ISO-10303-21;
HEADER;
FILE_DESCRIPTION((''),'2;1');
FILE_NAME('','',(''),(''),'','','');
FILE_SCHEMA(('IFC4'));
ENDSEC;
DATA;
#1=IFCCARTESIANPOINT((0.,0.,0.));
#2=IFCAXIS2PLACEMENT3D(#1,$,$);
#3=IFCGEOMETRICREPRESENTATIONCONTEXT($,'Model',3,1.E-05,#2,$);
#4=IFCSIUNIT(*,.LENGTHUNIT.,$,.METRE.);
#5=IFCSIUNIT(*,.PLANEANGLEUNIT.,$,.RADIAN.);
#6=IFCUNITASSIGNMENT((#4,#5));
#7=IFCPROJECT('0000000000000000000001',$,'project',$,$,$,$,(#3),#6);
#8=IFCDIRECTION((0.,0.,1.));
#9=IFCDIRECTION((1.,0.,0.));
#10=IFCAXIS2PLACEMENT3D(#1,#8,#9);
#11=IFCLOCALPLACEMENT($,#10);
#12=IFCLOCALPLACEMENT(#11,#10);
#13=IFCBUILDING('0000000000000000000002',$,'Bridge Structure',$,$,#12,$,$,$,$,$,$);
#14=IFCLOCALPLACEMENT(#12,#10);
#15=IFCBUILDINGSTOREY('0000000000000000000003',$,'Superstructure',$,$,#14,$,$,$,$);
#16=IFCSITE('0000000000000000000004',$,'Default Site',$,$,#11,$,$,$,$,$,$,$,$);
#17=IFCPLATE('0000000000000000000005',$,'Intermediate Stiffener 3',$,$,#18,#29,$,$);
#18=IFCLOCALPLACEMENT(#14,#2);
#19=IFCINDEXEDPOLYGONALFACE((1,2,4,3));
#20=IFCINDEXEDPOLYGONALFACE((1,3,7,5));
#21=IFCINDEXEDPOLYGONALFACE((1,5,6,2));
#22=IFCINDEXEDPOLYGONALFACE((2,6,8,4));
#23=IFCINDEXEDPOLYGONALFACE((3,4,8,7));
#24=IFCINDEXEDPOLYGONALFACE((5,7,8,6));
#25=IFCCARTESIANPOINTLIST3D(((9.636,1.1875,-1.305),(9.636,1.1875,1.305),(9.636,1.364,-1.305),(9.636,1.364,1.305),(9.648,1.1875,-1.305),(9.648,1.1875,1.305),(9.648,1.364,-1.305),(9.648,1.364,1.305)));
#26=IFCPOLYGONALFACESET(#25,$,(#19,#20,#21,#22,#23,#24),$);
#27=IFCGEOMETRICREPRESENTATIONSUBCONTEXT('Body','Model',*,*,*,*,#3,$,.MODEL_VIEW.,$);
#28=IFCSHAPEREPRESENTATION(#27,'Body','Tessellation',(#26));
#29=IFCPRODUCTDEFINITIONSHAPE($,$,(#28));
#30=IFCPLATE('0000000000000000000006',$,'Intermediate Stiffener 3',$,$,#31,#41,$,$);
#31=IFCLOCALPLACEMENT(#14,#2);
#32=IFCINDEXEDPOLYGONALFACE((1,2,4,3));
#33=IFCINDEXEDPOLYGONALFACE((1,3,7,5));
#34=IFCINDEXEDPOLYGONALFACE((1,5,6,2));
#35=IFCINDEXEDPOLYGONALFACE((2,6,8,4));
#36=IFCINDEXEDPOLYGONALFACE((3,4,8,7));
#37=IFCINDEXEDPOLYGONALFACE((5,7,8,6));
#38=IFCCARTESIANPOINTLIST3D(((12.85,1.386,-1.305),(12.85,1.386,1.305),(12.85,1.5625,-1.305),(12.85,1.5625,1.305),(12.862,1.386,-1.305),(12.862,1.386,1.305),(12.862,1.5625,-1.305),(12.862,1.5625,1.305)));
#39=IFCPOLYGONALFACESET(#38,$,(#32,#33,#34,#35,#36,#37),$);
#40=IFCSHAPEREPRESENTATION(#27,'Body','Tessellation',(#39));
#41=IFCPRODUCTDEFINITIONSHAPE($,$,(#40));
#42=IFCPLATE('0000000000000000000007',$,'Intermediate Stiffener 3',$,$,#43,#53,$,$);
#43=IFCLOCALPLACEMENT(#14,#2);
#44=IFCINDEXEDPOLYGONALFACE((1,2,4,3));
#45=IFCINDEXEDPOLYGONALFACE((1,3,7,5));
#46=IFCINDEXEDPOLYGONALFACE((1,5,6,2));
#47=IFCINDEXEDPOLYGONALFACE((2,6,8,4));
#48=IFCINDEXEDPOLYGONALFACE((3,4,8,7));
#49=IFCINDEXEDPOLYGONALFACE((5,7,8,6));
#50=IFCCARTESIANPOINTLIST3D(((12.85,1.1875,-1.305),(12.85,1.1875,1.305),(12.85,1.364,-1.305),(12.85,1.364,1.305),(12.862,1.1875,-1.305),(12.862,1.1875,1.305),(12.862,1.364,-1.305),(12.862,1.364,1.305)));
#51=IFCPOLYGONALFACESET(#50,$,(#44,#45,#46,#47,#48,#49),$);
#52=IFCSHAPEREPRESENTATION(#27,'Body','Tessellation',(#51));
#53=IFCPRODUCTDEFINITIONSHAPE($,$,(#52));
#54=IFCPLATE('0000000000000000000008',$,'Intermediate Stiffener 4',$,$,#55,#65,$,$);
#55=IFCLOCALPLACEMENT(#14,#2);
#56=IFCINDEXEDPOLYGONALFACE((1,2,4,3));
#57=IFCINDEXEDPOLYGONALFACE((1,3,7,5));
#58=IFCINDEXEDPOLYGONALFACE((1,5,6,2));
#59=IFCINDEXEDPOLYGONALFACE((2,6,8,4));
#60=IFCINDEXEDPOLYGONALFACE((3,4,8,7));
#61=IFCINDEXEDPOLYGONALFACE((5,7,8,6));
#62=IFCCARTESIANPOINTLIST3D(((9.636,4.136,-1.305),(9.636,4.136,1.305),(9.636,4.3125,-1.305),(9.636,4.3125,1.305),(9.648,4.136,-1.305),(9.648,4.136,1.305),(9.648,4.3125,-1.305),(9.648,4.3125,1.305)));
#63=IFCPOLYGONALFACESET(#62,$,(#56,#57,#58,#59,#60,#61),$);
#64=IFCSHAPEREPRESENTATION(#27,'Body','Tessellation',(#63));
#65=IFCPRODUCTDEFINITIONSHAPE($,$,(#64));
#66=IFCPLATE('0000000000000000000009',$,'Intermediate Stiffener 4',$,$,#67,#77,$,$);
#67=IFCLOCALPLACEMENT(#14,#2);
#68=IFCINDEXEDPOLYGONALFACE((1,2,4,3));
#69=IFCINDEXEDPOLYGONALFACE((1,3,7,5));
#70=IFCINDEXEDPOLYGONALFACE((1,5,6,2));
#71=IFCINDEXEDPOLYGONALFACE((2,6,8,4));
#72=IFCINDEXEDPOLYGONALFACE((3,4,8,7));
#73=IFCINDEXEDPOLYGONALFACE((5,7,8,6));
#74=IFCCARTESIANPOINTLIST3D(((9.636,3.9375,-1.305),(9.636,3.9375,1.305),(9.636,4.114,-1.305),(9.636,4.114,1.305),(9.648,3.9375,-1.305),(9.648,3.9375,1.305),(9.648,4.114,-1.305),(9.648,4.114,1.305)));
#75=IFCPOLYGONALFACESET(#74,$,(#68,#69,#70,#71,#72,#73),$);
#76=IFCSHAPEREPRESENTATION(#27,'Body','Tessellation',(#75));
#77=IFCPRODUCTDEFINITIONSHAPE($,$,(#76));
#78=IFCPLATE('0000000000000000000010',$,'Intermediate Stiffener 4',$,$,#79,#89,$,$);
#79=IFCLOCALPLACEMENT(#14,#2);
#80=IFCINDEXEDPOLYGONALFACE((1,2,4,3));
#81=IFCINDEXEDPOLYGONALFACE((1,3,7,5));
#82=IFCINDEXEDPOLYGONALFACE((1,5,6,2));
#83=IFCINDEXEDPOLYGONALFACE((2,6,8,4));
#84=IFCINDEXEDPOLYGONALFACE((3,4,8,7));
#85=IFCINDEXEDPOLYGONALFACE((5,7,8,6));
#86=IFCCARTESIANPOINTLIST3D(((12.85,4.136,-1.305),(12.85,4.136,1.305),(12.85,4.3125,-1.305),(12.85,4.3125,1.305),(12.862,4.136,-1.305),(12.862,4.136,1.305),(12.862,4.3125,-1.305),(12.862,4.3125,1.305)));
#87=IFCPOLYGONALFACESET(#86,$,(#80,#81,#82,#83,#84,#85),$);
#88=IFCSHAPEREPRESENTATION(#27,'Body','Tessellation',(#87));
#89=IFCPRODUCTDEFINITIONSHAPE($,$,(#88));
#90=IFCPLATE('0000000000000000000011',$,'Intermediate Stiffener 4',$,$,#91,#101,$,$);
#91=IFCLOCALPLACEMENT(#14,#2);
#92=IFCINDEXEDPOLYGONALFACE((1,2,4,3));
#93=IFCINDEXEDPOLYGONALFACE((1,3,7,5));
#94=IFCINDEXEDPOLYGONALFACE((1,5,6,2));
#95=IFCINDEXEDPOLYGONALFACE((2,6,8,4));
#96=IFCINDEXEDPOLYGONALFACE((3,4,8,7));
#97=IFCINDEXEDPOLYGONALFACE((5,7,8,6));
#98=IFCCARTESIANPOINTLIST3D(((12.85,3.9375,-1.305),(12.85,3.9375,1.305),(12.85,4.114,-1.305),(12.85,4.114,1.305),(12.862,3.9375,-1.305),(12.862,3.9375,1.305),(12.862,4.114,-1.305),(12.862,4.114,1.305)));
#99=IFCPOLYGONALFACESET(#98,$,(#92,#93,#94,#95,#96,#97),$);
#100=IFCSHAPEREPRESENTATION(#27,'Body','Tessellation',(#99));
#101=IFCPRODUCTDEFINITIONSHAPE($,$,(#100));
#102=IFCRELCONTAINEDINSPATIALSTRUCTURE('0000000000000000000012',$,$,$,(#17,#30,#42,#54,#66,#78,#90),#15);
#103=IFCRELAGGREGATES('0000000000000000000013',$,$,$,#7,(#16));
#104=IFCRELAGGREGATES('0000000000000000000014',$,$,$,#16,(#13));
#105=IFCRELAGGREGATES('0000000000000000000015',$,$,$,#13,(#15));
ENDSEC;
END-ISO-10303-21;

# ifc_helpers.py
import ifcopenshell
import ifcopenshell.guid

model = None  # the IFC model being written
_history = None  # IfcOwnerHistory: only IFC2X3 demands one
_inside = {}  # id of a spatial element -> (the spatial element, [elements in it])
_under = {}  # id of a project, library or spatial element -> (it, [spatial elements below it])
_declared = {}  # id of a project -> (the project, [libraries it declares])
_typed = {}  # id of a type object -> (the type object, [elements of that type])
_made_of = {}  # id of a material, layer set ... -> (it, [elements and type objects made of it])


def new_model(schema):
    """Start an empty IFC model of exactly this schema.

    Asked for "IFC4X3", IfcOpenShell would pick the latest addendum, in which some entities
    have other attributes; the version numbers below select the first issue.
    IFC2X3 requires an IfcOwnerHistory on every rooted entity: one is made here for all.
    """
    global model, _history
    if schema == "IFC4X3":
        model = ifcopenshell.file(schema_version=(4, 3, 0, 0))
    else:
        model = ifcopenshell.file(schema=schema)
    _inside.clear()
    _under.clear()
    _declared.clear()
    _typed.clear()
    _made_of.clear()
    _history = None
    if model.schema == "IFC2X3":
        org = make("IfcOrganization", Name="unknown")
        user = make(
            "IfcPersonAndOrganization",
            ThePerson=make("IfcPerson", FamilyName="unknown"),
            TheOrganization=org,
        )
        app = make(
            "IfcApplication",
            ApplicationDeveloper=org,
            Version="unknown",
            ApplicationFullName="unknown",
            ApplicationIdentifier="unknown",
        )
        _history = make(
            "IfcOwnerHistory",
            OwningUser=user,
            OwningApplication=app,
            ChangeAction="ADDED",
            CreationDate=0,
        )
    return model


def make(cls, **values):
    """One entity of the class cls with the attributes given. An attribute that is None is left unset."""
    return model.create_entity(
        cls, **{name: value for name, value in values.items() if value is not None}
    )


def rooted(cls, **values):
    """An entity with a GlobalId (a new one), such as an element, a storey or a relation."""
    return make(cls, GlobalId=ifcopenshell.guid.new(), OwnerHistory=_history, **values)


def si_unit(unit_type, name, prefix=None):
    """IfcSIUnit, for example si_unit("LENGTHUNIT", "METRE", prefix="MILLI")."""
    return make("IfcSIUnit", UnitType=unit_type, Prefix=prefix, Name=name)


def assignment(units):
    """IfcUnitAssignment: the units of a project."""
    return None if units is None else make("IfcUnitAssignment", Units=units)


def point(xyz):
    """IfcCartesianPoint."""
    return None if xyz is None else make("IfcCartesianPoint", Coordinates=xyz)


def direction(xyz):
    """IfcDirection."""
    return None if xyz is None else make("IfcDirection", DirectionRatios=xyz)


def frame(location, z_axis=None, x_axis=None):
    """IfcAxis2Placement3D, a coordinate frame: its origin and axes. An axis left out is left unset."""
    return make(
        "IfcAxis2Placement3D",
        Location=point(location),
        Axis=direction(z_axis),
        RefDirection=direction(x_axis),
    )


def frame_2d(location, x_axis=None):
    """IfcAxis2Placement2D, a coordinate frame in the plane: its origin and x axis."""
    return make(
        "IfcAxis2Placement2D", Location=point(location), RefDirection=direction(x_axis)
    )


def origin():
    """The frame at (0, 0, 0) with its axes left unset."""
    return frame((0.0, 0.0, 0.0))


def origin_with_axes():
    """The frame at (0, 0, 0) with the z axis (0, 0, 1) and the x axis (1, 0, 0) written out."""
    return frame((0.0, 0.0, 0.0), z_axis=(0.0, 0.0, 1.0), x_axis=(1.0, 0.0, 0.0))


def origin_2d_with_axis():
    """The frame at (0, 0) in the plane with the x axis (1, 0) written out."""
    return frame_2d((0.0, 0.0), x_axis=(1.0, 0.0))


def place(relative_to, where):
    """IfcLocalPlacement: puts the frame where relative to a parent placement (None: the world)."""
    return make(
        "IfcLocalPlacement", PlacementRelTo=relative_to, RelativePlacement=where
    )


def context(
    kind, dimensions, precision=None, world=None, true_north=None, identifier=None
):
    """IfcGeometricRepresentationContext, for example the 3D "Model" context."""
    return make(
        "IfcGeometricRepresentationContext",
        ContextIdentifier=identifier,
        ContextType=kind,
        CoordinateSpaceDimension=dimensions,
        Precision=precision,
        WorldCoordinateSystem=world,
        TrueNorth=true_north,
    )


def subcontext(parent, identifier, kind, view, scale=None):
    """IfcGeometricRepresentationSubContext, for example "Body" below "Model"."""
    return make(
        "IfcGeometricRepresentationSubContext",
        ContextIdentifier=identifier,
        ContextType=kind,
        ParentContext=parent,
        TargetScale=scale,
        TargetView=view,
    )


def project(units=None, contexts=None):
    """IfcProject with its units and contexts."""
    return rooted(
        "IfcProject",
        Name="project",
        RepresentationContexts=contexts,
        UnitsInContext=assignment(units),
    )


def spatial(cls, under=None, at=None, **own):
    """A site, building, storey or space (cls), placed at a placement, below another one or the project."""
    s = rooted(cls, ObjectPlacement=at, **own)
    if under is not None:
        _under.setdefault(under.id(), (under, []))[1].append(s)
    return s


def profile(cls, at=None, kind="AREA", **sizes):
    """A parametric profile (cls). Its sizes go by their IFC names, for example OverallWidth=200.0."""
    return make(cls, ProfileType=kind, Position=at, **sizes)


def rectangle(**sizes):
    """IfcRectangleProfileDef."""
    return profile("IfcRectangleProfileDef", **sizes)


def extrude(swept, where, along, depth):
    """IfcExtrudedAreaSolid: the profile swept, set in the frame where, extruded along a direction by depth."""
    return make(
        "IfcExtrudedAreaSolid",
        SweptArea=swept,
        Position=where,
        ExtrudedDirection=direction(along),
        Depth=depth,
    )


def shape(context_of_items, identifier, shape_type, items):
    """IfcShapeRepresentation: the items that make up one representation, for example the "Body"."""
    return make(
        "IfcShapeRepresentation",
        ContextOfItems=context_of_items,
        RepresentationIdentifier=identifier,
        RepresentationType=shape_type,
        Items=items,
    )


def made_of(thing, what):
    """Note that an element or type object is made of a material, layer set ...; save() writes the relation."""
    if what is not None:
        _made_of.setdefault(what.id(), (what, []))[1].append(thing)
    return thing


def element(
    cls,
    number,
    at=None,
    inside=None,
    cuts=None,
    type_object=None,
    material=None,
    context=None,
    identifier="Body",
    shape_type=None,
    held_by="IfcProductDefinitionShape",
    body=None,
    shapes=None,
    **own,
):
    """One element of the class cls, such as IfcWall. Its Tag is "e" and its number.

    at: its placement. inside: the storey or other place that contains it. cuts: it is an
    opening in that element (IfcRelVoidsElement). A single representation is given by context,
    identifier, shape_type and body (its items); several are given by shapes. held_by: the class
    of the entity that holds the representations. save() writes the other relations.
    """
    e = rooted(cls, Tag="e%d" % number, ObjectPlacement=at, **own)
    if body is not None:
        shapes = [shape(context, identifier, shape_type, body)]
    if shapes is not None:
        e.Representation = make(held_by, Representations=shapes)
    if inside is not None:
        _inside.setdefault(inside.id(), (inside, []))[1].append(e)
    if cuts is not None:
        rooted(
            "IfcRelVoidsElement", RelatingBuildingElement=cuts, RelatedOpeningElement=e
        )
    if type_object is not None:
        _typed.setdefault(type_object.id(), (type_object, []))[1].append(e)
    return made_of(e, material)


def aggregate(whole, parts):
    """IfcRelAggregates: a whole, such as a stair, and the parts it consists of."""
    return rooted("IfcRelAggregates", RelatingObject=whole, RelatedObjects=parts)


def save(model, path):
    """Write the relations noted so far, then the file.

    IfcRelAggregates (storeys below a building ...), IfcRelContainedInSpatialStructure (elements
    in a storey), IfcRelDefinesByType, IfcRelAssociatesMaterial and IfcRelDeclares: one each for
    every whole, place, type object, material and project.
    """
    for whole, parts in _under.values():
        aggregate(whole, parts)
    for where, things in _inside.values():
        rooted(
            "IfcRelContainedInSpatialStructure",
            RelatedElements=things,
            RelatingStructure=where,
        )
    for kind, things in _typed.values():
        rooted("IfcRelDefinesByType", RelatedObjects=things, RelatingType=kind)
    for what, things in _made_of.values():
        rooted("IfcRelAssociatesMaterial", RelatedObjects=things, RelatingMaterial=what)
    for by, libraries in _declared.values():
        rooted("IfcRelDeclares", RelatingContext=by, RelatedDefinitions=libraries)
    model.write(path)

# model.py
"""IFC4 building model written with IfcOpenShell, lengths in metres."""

from ifc_helpers import new_model, si_unit, frame, origin, origin_with_axes, origin_2d_with_axis, place, context, subcontext, project, spatial, rectangle, extrude, element, save


model = new_model("IFC4")

# Units and contexts
model_context = context("Model", 3, precision=1e-05, world=origin())
body_context = subcontext(model_context, "Body", "Model", "MODEL_VIEW")
ifc_project = project(units=[si_unit("LENGTHUNIT", "METRE"), si_unit("PLANEANGLEUNIT", "RADIAN")], contexts=[model_context])

# Site, building, storey
site_placement = place(None, origin_with_axes())
site = spatial("IfcSite", under=ifc_project, at=site_placement, Name="Default Site")
building_placement = place(site_placement, origin_with_axes())
building = spatial("IfcBuilding", under=site, at=building_placement, Name="Bridge Structure")
storey_placement = place(building_placement, origin_with_axes())
storey = spatial("IfcBuildingStorey", under=building, at=storey_placement, Name="Superstructure")

# Plates
for number, where, z_axis, x_axis, name in (
    (1, (9.642, 1.2757, -1.305), (0.0, 0.0, 1.0), (1.0, 0.0, 0.0), "Intermediate Stiffener 3"),
    (2, (12.856, 1.4743, -1.305), (0.0, 0.0, 1.0), (1.0, 0.0, 0.0), "Intermediate Stiffener 3"),
    (3, (12.856, 1.2757, -1.305), (0.0, 0.0, 1.0), (1.0, 0.0, 0.0), "Intermediate Stiffener 3"),
    (4, (9.642, 4.2243, -1.305), (0.0, 0.0, 1.0), (1.0, 0.0, 0.0), "Intermediate Stiffener 4"),
    (5, (9.642, 4.0258, -1.305), (0.0, 0.0, 1.0), (1.0, 0.0, 0.0), "Intermediate Stiffener 4"),
    (6, (12.856, 4.2243, -1.305), (0.0, 0.0, 1.0), (1.0, 0.0, 0.0), "Intermediate Stiffener 4"),
    (7, (12.856, 4.0258, -1.305), (0.0, 0.0, 1.0), (1.0, 0.0, 0.0), "Intermediate Stiffener 4"),
):
    element("IfcPlate", number, at=place(storey_placement, frame(where, z_axis=z_axis, x_axis=x_axis)), inside=storey, Name=name, context=body_context, shape_type="SweptSolid", body=[
        extrude(rectangle(XDim=0.012, YDim=0.1765, at=origin_2d_with_axis()), origin_with_axes(), (0.0, 0.0, 1.0), 2.61),
    ])

save(model, "model.ifc")
